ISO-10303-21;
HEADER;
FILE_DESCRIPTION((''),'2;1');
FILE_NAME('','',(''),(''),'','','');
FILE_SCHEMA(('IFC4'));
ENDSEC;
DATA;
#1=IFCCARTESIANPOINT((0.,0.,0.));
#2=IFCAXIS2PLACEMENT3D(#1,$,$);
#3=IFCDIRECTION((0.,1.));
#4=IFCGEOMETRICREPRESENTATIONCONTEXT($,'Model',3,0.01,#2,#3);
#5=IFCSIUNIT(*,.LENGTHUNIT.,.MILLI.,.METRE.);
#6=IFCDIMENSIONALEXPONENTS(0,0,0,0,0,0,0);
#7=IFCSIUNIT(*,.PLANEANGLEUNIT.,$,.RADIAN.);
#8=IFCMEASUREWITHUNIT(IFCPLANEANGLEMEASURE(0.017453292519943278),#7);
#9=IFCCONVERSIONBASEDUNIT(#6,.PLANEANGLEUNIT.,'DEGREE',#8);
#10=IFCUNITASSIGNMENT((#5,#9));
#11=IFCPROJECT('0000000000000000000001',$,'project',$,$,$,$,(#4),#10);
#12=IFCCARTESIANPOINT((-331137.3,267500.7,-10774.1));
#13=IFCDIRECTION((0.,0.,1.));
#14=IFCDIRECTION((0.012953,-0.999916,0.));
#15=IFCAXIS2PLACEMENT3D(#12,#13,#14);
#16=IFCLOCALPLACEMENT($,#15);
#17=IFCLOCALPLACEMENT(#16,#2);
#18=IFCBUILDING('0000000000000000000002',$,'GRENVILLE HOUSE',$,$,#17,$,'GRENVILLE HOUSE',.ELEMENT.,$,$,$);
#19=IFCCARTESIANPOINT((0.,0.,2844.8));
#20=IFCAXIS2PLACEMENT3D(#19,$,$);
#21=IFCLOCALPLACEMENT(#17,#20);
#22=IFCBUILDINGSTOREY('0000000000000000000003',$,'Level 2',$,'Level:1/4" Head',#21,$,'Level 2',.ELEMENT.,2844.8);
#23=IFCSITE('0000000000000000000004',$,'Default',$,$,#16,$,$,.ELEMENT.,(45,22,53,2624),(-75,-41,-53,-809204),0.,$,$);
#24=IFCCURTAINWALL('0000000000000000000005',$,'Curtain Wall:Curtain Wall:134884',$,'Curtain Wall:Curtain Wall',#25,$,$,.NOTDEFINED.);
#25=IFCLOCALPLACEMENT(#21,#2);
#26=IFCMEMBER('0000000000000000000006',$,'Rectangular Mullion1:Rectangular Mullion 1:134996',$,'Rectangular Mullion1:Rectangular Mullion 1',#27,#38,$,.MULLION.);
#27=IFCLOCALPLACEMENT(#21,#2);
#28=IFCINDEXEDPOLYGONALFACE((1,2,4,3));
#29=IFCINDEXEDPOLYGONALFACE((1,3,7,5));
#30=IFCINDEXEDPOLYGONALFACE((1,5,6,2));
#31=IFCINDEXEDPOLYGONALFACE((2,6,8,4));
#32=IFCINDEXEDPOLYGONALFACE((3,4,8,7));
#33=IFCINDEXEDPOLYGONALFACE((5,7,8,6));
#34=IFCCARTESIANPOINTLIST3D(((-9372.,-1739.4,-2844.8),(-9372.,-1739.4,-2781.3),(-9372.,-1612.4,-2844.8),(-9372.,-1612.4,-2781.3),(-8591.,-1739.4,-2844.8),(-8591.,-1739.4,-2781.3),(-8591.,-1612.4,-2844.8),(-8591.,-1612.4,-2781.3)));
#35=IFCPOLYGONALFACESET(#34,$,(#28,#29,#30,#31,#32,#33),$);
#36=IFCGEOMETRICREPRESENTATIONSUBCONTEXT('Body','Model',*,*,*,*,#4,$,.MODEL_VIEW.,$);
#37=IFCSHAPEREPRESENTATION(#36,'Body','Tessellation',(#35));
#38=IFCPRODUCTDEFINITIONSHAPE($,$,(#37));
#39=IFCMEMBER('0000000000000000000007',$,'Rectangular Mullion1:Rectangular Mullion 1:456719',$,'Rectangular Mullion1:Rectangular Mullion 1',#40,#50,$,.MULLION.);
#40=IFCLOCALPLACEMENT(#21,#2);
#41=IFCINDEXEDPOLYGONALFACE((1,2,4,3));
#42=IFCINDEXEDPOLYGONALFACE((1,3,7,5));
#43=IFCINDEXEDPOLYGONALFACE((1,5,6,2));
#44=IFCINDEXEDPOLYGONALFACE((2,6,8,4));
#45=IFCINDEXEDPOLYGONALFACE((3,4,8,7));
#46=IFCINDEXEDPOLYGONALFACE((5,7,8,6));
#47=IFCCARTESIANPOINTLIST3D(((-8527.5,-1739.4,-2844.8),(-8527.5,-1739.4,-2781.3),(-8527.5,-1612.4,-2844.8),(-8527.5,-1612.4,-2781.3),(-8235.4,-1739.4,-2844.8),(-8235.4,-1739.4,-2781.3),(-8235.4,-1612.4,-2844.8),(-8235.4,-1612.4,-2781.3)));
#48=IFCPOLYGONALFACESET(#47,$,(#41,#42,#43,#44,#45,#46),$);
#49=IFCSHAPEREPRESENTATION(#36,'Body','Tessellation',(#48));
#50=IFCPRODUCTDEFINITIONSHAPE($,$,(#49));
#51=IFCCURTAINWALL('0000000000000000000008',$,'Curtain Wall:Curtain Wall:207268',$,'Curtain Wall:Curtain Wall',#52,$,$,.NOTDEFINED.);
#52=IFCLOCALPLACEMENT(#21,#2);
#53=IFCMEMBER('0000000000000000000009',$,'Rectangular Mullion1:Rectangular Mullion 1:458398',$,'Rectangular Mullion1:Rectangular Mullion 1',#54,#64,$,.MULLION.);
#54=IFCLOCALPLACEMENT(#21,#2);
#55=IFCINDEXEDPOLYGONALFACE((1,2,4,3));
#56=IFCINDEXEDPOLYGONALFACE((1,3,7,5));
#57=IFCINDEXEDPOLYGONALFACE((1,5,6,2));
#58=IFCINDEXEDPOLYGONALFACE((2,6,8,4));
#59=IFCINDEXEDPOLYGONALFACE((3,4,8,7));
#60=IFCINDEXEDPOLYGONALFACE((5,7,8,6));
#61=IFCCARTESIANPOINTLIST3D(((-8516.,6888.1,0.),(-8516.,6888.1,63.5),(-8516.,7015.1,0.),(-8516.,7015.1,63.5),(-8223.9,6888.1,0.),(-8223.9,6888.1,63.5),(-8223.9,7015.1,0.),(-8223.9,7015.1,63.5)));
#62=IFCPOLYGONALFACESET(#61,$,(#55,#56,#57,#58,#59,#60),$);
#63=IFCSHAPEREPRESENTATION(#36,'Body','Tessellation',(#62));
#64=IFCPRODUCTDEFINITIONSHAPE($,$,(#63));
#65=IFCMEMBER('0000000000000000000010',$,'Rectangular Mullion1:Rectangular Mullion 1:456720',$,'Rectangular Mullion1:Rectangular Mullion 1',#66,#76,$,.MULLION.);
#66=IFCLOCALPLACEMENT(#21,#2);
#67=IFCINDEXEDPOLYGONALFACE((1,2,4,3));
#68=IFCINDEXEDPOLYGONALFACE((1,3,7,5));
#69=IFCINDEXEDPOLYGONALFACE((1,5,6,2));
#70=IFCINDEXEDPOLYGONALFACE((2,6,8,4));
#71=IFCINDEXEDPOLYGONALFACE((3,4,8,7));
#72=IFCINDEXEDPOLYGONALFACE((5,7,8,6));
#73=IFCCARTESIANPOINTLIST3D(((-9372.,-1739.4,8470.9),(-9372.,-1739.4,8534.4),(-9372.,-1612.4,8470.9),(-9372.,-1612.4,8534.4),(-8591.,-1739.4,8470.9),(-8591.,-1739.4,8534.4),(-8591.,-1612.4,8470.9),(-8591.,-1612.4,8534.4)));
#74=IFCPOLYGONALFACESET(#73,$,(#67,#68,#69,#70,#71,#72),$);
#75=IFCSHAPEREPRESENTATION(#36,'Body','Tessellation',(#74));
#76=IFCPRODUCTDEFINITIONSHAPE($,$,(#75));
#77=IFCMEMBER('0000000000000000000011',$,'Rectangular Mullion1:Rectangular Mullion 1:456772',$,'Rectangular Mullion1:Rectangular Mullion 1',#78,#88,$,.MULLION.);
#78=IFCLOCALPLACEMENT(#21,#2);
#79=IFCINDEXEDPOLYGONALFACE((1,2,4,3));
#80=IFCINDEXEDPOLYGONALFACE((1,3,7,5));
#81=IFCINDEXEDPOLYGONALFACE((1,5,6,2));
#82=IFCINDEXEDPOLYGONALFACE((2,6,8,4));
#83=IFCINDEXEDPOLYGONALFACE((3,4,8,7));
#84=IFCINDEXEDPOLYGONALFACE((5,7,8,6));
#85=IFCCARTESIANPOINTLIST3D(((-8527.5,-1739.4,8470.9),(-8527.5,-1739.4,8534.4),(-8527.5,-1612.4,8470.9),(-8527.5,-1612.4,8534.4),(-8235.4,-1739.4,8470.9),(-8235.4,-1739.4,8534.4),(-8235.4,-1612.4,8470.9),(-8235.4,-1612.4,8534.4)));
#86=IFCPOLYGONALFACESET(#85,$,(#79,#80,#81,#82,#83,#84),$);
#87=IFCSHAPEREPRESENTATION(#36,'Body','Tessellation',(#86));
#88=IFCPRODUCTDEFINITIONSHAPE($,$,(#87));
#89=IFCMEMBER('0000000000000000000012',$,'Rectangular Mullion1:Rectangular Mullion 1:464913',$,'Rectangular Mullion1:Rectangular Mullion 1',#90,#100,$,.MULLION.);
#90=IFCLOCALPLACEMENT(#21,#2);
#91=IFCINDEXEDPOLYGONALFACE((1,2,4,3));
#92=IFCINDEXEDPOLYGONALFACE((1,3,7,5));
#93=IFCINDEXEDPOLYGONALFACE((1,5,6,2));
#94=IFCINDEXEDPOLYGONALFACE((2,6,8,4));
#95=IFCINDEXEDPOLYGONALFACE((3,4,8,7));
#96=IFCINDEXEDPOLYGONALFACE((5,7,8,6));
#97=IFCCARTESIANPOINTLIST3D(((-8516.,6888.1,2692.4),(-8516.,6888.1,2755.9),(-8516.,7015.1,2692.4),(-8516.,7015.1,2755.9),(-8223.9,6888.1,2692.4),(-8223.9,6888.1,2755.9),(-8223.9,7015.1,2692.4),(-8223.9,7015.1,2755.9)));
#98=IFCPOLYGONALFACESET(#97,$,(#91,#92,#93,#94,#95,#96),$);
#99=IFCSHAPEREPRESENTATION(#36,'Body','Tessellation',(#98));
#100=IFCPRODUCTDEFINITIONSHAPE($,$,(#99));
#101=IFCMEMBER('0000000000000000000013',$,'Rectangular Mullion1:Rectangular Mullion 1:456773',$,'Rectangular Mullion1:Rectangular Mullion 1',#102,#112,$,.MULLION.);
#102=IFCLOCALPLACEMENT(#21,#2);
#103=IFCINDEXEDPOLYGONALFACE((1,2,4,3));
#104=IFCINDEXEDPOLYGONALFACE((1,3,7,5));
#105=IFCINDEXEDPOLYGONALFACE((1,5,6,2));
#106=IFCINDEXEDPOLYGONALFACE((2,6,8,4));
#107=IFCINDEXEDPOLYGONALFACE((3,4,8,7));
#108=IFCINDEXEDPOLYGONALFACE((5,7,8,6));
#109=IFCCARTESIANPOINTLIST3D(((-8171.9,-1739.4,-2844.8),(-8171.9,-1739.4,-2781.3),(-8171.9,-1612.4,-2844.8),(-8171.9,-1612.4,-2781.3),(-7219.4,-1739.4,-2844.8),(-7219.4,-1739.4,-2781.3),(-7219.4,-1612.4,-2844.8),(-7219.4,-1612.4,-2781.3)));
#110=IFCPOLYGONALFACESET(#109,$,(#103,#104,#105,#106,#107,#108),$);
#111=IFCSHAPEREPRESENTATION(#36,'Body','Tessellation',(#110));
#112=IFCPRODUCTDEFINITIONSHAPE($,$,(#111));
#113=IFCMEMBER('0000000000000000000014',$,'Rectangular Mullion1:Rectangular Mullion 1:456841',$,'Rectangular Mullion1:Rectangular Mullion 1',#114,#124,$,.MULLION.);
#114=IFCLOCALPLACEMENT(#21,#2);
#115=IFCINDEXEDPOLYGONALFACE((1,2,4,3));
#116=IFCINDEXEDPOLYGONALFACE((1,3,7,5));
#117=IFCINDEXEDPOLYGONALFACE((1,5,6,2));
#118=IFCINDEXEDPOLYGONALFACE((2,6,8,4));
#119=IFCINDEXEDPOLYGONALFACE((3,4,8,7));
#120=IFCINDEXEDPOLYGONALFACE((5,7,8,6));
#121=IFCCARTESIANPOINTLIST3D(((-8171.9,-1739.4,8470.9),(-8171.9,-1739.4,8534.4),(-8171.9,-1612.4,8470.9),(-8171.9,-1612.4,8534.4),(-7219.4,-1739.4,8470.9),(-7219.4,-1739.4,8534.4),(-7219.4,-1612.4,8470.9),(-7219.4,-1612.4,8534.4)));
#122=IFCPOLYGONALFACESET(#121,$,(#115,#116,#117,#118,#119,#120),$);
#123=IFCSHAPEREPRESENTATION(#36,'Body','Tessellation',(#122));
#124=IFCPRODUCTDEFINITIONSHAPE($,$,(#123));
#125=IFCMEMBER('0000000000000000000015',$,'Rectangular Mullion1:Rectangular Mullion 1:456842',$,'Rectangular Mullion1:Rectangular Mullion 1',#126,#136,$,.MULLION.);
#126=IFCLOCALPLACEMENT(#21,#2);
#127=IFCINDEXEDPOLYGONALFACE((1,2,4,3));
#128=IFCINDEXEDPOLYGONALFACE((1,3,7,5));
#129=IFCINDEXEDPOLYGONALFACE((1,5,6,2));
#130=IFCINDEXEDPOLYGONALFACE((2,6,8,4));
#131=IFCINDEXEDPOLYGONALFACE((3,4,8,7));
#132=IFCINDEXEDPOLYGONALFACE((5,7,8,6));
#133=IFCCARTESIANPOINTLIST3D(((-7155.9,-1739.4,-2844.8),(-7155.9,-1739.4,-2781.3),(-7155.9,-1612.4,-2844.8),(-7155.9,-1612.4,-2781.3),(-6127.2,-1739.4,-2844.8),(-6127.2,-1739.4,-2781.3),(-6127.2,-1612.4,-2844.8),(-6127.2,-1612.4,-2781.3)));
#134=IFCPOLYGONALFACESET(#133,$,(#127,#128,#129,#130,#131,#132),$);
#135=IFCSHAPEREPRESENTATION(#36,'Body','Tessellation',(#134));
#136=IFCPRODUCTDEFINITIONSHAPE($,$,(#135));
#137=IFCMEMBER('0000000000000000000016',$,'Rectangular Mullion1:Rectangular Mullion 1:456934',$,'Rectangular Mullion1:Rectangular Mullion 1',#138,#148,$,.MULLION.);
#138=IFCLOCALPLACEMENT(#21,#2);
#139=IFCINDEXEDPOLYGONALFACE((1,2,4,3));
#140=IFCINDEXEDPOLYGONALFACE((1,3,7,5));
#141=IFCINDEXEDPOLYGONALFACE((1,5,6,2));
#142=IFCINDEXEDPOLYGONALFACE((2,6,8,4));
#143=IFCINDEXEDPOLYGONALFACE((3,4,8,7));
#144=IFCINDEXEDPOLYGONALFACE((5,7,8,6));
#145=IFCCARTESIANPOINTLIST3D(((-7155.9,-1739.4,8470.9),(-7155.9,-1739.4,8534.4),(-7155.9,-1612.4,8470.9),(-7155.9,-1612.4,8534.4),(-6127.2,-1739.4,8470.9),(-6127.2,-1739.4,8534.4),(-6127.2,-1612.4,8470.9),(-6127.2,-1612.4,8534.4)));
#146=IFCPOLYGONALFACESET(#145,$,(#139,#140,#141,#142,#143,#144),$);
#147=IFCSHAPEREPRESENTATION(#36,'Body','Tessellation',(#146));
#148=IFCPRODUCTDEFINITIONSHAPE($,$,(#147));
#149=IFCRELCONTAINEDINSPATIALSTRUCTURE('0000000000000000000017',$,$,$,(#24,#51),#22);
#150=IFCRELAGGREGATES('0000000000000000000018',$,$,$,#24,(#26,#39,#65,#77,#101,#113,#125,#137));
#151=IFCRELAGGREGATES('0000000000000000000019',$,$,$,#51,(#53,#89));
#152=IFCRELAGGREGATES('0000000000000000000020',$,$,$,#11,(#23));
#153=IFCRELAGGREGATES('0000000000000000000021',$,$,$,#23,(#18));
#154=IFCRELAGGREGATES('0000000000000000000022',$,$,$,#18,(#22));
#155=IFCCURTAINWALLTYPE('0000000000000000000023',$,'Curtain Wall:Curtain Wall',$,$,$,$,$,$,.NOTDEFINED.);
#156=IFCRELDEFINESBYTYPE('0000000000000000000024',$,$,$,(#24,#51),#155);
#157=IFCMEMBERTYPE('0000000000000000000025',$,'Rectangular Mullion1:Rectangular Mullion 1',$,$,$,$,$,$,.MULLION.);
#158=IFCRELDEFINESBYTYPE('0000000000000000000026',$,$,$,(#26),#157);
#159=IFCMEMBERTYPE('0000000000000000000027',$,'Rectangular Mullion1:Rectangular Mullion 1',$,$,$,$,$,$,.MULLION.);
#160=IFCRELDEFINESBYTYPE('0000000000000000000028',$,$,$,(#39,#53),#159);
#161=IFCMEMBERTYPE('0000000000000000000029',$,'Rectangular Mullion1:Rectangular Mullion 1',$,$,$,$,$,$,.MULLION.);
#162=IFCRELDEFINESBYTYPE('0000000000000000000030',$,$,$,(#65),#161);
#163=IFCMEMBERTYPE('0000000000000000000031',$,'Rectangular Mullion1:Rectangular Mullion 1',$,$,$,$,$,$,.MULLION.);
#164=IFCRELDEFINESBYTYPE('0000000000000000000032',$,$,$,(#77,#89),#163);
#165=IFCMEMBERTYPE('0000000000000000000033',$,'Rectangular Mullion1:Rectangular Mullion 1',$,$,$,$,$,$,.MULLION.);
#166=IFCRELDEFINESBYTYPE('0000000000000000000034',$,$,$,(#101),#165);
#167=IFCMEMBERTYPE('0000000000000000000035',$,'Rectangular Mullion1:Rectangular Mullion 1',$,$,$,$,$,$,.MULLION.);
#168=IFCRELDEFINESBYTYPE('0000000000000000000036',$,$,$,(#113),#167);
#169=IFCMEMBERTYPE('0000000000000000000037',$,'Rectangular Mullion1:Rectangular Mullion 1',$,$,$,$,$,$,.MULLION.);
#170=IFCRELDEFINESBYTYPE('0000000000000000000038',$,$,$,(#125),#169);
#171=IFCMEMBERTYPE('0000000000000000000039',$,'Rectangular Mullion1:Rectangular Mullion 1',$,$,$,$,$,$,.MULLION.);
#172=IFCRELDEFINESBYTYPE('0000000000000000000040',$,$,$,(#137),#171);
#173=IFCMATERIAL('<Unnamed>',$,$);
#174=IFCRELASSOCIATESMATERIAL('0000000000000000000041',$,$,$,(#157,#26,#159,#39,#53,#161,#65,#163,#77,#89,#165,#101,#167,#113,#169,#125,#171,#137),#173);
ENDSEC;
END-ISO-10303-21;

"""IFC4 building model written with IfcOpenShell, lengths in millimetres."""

from ifc_helpers import new_model, entity, si_unit, converted_unit, direction, frame, origin, place, context, subcontext, project, spatial, indexed_curve, outline, extrude, source, transform, mapped, material, type_object, type_shapes, element, aggregate, save


model = new_model("IFC4")

# Units and contexts
model_context = context("Model", 3, precision=0.01, world=origin(), true_north=direction((0.0, 1.0)))
body_context = subcontext(model_context, "Body", "Model", "MODEL_VIEW")
ifc_project = project(units=[si_unit("LENGTHUNIT", "METRE", prefix="MILLI"), converted_unit("PLANEANGLEUNIT", "DEGREE", entity("IfcPlaneAngleMeasure", 0.017453292519943278), si_unit("PLANEANGLEUNIT", "RADIAN"), dimensions=[0, 0, 0, 0, 0, 0, 0])], contexts=[model_context])

# Site, building, storey
site_placement = place(None, frame((-331137.3, 267500.7, -10774.1), z_axis=(0.0, 0.0, 1.0), x_axis=(0.012953, -0.999916, 0.0)))
site = spatial("IfcSite", under=ifc_project, at=site_placement, Name="Default", CompositionType="ELEMENT", RefLatitude=(45, 22, 53, 2624), RefLongitude=(-75, -41, -53, -809204), RefElevation=0.0)
building_placement = place(site_placement, origin())
building = spatial("IfcBuilding", under=site, at=building_placement, Name="GRENVILLE HOUSE", LongName="GRENVILLE HOUSE", CompositionType="ELEMENT")
storey_placement = place(building_placement, frame((0.0, 0.0, 2844.8)))
storey = spatial("IfcBuildingStorey", under=building, at=storey_placement, Name="Level 2", ObjectType="Level:1/4\" Head", LongName="Level 2", CompositionType="ELEMENT", Elevation=2844.8)

# Curtain wall, members
curtain_wall_type = type_object("IfcCurtainWallType", Name="Curtain Wall:Curtain Wall", PredefinedType="NOTDEFINED")
curtain_wall_1_placement = place(storey_placement, frame((0.0, 0.0, -2844.8)))
curtain_wall_1 = element("IfcCurtainWall", 1, at=curtain_wall_1_placement, inside=storey, type_object=curtain_wall_type, Name="Curtain Wall:Curtain Wall:134884", ObjectType="Curtain Wall:Curtain Wall", PredefinedType="NOTDEFINED")
ifc_material_1 = material(Name="<Unnamed>")
member_type_1 = type_object("IfcMemberType", Name="Rectangular Mullion1:Rectangular Mullion 1", PredefinedType="MULLION", material=ifc_material_1)
shared_shape_1 = source(origin(), body_context, "Body", "SweptSolid", [
    extrude(outline(indexed_curve([(-31.8, -63.5), (31.8, -63.5), (31.8, 63.5), (-31.8, 63.5), (-31.8, -63.5)], self_intersect=False)), frame((-31.8, 0.0, -781.1), z_axis=(0.0, 0.0, 1.0), x_axis=(-1.0, 0.0, 0.0)), (0.0, 0.0, 1.0), 781.1),
])
type_shapes(member_type_1, [shared_shape_1])
member_1_placement = place(curtain_wall_1_placement, frame((-9372.0, -1675.9, 0.0), z_axis=(-1.0, 0.0, 0.0), x_axis=(0.0, 0.0, -1.0)))
member_1 = element("IfcMember", 2, at=member_1_placement, type_object=member_type_1, material=ifc_material_1, Name="Rectangular Mullion1:Rectangular Mullion 1:134996", ObjectType="Rectangular Mullion1:Rectangular Mullion 1", PredefinedType="MULLION", context=body_context, shape_type="MappedRepresentation", body=[
    mapped(shared_shape_1, transform((0.0, 0.0, 0.0), scale=1.0)),
])
member_type_2 = type_object("IfcMemberType", Name="Rectangular Mullion1:Rectangular Mullion 1", PredefinedType="MULLION", material=ifc_material_1)
shared_shape_2 = source(origin(), body_context, "Body", "SweptSolid", [
    extrude(outline(indexed_curve([(-31.8, -63.5), (31.8, -63.5), (31.8, 63.5), (-31.8, 63.5), (-31.8, -63.5)], self_intersect=False)), frame((-31.8, 0.0, -292.1), z_axis=(0.0, 0.0, 1.0), x_axis=(-1.0, 0.0, 0.0)), (0.0, 0.0, 1.0), 292.1),
])
type_shapes(member_type_2, [shared_shape_2])
member_2_placement = place(curtain_wall_1_placement, frame((-8527.5, -1675.9, 0.0), z_axis=(-1.0, 0.0, 0.0), x_axis=(0.0, 0.0, -1.0)))
member_2 = element("IfcMember", 3, at=member_2_placement, type_object=member_type_2, material=ifc_material_1, Name="Rectangular Mullion1:Rectangular Mullion 1:456719", ObjectType="Rectangular Mullion1:Rectangular Mullion 1", PredefinedType="MULLION", context=body_context, shape_type="MappedRepresentation", body=[
    mapped(shared_shape_2, transform((0.0, 0.0, 0.0), scale=1.0)),
])

# Curtain wall, member
curtain_wall_2_placement = place(storey_placement, frame((0.0, 0.0, -2844.8)))
curtain_wall_2 = element("IfcCurtainWall", 4, at=curtain_wall_2_placement, inside=storey, type_object=curtain_wall_type, Name="Curtain Wall:Curtain Wall:207268", ObjectType="Curtain Wall:Curtain Wall", PredefinedType="NOTDEFINED")
member_3_placement = place(curtain_wall_2_placement, frame((-8223.9, 6951.6, 2844.8), z_axis=(1.0, 0.0, 0.0), x_axis=(0.0, 0.0, -1.0)))
member_3 = element("IfcMember", 5, at=member_3_placement, type_object=member_type_2, material=ifc_material_1, Name="Rectangular Mullion1:Rectangular Mullion 1:458398", ObjectType="Rectangular Mullion1:Rectangular Mullion 1", PredefinedType="MULLION", context=body_context, shape_type="MappedRepresentation", body=[
    mapped(shared_shape_2, transform((0.0, 0.0, 0.0), scale=1.0)),
])

# Members
member_type_3 = type_object("IfcMemberType", Name="Rectangular Mullion1:Rectangular Mullion 1", PredefinedType="MULLION", material=ifc_material_1)
shared_shape_3 = source(origin(), body_context, "Body", "SweptSolid", [
    extrude(outline(indexed_curve([(-31.8, -63.5), (31.8, -63.5), (31.8, 63.5), (-31.8, 63.5), (-31.8, -63.5)], self_intersect=False)), frame((-31.8, 0.0, -781.1), z_axis=(0.0, 0.0, 1.0), x_axis=(-1.0, 0.0, 0.0)), (0.0, 0.0, 1.0), 781.1),
])
type_shapes(member_type_3, [shared_shape_3])
member_4_placement = place(curtain_wall_1_placement, frame((-8591.0, -1675.9, 11379.2), z_axis=(1.0, 0.0, 0.0), x_axis=(0.0, 0.0, 1.0)))
member_4 = element("IfcMember", 6, at=member_4_placement, type_object=member_type_3, material=ifc_material_1, Name="Rectangular Mullion1:Rectangular Mullion 1:456720", ObjectType="Rectangular Mullion1:Rectangular Mullion 1", PredefinedType="MULLION", context=body_context, shape_type="MappedRepresentation", body=[
    mapped(shared_shape_3, transform((0.0, 0.0, 0.0), scale=1.0)),
])
member_type_4 = type_object("IfcMemberType", Name="Rectangular Mullion1:Rectangular Mullion 1", PredefinedType="MULLION", material=ifc_material_1)
shared_shape_4 = source(origin(), body_context, "Body", "SweptSolid", [
    extrude(outline(indexed_curve([(-31.8, -63.5), (31.8, -63.5), (31.8, 63.5), (-31.8, 63.5), (-31.8, -63.5)], self_intersect=False)), frame((-31.8, 0.0, -292.1), z_axis=(0.0, 0.0, 1.0), x_axis=(-1.0, 0.0, 0.0)), (0.0, 0.0, 1.0), 292.1),
])
type_shapes(member_type_4, [shared_shape_4])
member_5_placement = place(curtain_wall_1_placement, frame((-8235.4, -1675.9, 11379.2), z_axis=(1.0, 0.0, 0.0), x_axis=(0.0, 0.0, 1.0)))
member_5 = element("IfcMember", 7, at=member_5_placement, type_object=member_type_4, material=ifc_material_1, Name="Rectangular Mullion1:Rectangular Mullion 1:456772", ObjectType="Rectangular Mullion1:Rectangular Mullion 1", PredefinedType="MULLION", context=body_context, shape_type="MappedRepresentation", body=[
    mapped(shared_shape_4, transform((0.0, 0.0, 0.0), scale=1.0)),
])
member_6_placement = place(curtain_wall_2_placement, frame((-8516.0, 6951.6, 5600.7), z_axis=(-1.0, 0.0, 0.0), x_axis=(0.0, 0.0, 1.0)))
member_6 = element("IfcMember", 8, at=member_6_placement, type_object=member_type_4, material=ifc_material_1, Name="Rectangular Mullion1:Rectangular Mullion 1:464913", ObjectType="Rectangular Mullion1:Rectangular Mullion 1", PredefinedType="MULLION", context=body_context, shape_type="MappedRepresentation", body=[
    mapped(shared_shape_4, transform((0.0, 0.0, 0.0), scale=1.0)),
])
member_type_5 = type_object("IfcMemberType", Name="Rectangular Mullion1:Rectangular Mullion 1", PredefinedType="MULLION", material=ifc_material_1)
shared_shape_5 = source(origin(), body_context, "Body", "SweptSolid", [
    extrude(outline(indexed_curve([(-31.8, -63.5), (31.8, -63.5), (31.8, 63.5), (-31.8, 63.5), (-31.8, -63.5)], self_intersect=False)), frame((-31.8, 0.0, -952.5), z_axis=(0.0, 0.0, 1.0), x_axis=(-1.0, 0.0, 0.0)), (0.0, 0.0, 1.0), 952.5),
])
type_shapes(member_type_5, [shared_shape_5])
member_7_placement = place(curtain_wall_1_placement, frame((-8171.9, -1675.9, 0.0), z_axis=(-1.0, 0.0, 0.0), x_axis=(0.0, 0.0, -1.0)))
member_7 = element("IfcMember", 9, at=member_7_placement, type_object=member_type_5, material=ifc_material_1, Name="Rectangular Mullion1:Rectangular Mullion 1:456773", ObjectType="Rectangular Mullion1:Rectangular Mullion 1", PredefinedType="MULLION", context=body_context, shape_type="MappedRepresentation", body=[
    mapped(shared_shape_5, transform((0.0, 0.0, 0.0), scale=1.0)),
])
member_type_6 = type_object("IfcMemberType", Name="Rectangular Mullion1:Rectangular Mullion 1", PredefinedType="MULLION", material=ifc_material_1)
shared_shape_6 = source(origin(), body_context, "Body", "SweptSolid", [
    extrude(outline(indexed_curve([(-31.8, -63.5), (31.8, -63.5), (31.8, 63.5), (-31.8, 63.5), (-31.8, -63.5)], self_intersect=False)), frame((-31.8, 0.0, -952.5), z_axis=(0.0, 0.0, 1.0), x_axis=(-1.0, 0.0, 0.0)), (0.0, 0.0, 1.0), 952.5),
])
type_shapes(member_type_6, [shared_shape_6])
member_8_placement = place(curtain_wall_1_placement, frame((-7219.4, -1675.9, 11379.2), z_axis=(1.0, 0.0, 0.0), x_axis=(0.0, 0.0, 1.0)))
member_8 = element("IfcMember", 10, at=member_8_placement, type_object=member_type_6, material=ifc_material_1, Name="Rectangular Mullion1:Rectangular Mullion 1:456841", ObjectType="Rectangular Mullion1:Rectangular Mullion 1", PredefinedType="MULLION", context=body_context, shape_type="MappedRepresentation", body=[
    mapped(shared_shape_6, transform((0.0, 0.0, 0.0), scale=1.0)),
])
member_type_7 = type_object("IfcMemberType", Name="Rectangular Mullion1:Rectangular Mullion 1", PredefinedType="MULLION", material=ifc_material_1)
shared_shape_7 = source(origin(), body_context, "Body", "SweptSolid", [
    extrude(outline(indexed_curve([(-31.8, -63.5), (31.8, -63.5), (31.8, 63.5), (-31.8, 63.5), (-31.8, -63.5)], self_intersect=False)), frame((-31.8, 0.0, -1028.7), z_axis=(0.0, 0.0, 1.0), x_axis=(-1.0, 0.0, 0.0)), (0.0, 0.0, 1.0), 1028.7),
])
type_shapes(member_type_7, [shared_shape_7])
member_9_placement = place(curtain_wall_1_placement, frame((-7155.9, -1675.9, 0.0), z_axis=(-1.0, 0.0, 0.0), x_axis=(0.0, 0.0, -1.0)))
member_9 = element("IfcMember", 11, at=member_9_placement, type_object=member_type_7, material=ifc_material_1, Name="Rectangular Mullion1:Rectangular Mullion 1:456842", ObjectType="Rectangular Mullion1:Rectangular Mullion 1", PredefinedType="MULLION", context=body_context, shape_type="MappedRepresentation", body=[
    mapped(shared_shape_7, transform((0.0, 0.0, 0.0), scale=1.0)),
])
member_type_8 = type_object("IfcMemberType", Name="Rectangular Mullion1:Rectangular Mullion 1", PredefinedType="MULLION", material=ifc_material_1)
shared_shape_8 = source(origin(), body_context, "Body", "SweptSolid", [
    extrude(outline(indexed_curve([(-31.8, -63.5), (31.8, -63.5), (31.8, 63.5), (-31.8, 63.5), (-31.8, -63.5)], self_intersect=False)), frame((-31.8, 0.0, -1028.7), z_axis=(0.0, 0.0, 1.0), x_axis=(-1.0, 0.0, 0.0)), (0.0, 0.0, 1.0), 1028.7),
])
type_shapes(member_type_8, [shared_shape_8])
member_10_placement = place(curtain_wall_1_placement, frame((-6127.2, -1675.9, 11379.2), z_axis=(1.0, 0.0, 0.0), x_axis=(0.0, 0.0, 1.0)))
member_10 = element("IfcMember", 12, at=member_10_placement, type_object=member_type_8, material=ifc_material_1, Name="Rectangular Mullion1:Rectangular Mullion 1:456934", ObjectType="Rectangular Mullion1:Rectangular Mullion 1", PredefinedType="MULLION", context=body_context, shape_type="MappedRepresentation", body=[
    mapped(shared_shape_8, transform((0.0, 0.0, 0.0), scale=1.0)),
])

aggregate(curtain_wall_1, [member_1, member_2, member_4, member_5, member_7, member_8, member_9, member_10])
aggregate(curtain_wall_2, [member_3, member_6])

save(model, "model.ifc")
